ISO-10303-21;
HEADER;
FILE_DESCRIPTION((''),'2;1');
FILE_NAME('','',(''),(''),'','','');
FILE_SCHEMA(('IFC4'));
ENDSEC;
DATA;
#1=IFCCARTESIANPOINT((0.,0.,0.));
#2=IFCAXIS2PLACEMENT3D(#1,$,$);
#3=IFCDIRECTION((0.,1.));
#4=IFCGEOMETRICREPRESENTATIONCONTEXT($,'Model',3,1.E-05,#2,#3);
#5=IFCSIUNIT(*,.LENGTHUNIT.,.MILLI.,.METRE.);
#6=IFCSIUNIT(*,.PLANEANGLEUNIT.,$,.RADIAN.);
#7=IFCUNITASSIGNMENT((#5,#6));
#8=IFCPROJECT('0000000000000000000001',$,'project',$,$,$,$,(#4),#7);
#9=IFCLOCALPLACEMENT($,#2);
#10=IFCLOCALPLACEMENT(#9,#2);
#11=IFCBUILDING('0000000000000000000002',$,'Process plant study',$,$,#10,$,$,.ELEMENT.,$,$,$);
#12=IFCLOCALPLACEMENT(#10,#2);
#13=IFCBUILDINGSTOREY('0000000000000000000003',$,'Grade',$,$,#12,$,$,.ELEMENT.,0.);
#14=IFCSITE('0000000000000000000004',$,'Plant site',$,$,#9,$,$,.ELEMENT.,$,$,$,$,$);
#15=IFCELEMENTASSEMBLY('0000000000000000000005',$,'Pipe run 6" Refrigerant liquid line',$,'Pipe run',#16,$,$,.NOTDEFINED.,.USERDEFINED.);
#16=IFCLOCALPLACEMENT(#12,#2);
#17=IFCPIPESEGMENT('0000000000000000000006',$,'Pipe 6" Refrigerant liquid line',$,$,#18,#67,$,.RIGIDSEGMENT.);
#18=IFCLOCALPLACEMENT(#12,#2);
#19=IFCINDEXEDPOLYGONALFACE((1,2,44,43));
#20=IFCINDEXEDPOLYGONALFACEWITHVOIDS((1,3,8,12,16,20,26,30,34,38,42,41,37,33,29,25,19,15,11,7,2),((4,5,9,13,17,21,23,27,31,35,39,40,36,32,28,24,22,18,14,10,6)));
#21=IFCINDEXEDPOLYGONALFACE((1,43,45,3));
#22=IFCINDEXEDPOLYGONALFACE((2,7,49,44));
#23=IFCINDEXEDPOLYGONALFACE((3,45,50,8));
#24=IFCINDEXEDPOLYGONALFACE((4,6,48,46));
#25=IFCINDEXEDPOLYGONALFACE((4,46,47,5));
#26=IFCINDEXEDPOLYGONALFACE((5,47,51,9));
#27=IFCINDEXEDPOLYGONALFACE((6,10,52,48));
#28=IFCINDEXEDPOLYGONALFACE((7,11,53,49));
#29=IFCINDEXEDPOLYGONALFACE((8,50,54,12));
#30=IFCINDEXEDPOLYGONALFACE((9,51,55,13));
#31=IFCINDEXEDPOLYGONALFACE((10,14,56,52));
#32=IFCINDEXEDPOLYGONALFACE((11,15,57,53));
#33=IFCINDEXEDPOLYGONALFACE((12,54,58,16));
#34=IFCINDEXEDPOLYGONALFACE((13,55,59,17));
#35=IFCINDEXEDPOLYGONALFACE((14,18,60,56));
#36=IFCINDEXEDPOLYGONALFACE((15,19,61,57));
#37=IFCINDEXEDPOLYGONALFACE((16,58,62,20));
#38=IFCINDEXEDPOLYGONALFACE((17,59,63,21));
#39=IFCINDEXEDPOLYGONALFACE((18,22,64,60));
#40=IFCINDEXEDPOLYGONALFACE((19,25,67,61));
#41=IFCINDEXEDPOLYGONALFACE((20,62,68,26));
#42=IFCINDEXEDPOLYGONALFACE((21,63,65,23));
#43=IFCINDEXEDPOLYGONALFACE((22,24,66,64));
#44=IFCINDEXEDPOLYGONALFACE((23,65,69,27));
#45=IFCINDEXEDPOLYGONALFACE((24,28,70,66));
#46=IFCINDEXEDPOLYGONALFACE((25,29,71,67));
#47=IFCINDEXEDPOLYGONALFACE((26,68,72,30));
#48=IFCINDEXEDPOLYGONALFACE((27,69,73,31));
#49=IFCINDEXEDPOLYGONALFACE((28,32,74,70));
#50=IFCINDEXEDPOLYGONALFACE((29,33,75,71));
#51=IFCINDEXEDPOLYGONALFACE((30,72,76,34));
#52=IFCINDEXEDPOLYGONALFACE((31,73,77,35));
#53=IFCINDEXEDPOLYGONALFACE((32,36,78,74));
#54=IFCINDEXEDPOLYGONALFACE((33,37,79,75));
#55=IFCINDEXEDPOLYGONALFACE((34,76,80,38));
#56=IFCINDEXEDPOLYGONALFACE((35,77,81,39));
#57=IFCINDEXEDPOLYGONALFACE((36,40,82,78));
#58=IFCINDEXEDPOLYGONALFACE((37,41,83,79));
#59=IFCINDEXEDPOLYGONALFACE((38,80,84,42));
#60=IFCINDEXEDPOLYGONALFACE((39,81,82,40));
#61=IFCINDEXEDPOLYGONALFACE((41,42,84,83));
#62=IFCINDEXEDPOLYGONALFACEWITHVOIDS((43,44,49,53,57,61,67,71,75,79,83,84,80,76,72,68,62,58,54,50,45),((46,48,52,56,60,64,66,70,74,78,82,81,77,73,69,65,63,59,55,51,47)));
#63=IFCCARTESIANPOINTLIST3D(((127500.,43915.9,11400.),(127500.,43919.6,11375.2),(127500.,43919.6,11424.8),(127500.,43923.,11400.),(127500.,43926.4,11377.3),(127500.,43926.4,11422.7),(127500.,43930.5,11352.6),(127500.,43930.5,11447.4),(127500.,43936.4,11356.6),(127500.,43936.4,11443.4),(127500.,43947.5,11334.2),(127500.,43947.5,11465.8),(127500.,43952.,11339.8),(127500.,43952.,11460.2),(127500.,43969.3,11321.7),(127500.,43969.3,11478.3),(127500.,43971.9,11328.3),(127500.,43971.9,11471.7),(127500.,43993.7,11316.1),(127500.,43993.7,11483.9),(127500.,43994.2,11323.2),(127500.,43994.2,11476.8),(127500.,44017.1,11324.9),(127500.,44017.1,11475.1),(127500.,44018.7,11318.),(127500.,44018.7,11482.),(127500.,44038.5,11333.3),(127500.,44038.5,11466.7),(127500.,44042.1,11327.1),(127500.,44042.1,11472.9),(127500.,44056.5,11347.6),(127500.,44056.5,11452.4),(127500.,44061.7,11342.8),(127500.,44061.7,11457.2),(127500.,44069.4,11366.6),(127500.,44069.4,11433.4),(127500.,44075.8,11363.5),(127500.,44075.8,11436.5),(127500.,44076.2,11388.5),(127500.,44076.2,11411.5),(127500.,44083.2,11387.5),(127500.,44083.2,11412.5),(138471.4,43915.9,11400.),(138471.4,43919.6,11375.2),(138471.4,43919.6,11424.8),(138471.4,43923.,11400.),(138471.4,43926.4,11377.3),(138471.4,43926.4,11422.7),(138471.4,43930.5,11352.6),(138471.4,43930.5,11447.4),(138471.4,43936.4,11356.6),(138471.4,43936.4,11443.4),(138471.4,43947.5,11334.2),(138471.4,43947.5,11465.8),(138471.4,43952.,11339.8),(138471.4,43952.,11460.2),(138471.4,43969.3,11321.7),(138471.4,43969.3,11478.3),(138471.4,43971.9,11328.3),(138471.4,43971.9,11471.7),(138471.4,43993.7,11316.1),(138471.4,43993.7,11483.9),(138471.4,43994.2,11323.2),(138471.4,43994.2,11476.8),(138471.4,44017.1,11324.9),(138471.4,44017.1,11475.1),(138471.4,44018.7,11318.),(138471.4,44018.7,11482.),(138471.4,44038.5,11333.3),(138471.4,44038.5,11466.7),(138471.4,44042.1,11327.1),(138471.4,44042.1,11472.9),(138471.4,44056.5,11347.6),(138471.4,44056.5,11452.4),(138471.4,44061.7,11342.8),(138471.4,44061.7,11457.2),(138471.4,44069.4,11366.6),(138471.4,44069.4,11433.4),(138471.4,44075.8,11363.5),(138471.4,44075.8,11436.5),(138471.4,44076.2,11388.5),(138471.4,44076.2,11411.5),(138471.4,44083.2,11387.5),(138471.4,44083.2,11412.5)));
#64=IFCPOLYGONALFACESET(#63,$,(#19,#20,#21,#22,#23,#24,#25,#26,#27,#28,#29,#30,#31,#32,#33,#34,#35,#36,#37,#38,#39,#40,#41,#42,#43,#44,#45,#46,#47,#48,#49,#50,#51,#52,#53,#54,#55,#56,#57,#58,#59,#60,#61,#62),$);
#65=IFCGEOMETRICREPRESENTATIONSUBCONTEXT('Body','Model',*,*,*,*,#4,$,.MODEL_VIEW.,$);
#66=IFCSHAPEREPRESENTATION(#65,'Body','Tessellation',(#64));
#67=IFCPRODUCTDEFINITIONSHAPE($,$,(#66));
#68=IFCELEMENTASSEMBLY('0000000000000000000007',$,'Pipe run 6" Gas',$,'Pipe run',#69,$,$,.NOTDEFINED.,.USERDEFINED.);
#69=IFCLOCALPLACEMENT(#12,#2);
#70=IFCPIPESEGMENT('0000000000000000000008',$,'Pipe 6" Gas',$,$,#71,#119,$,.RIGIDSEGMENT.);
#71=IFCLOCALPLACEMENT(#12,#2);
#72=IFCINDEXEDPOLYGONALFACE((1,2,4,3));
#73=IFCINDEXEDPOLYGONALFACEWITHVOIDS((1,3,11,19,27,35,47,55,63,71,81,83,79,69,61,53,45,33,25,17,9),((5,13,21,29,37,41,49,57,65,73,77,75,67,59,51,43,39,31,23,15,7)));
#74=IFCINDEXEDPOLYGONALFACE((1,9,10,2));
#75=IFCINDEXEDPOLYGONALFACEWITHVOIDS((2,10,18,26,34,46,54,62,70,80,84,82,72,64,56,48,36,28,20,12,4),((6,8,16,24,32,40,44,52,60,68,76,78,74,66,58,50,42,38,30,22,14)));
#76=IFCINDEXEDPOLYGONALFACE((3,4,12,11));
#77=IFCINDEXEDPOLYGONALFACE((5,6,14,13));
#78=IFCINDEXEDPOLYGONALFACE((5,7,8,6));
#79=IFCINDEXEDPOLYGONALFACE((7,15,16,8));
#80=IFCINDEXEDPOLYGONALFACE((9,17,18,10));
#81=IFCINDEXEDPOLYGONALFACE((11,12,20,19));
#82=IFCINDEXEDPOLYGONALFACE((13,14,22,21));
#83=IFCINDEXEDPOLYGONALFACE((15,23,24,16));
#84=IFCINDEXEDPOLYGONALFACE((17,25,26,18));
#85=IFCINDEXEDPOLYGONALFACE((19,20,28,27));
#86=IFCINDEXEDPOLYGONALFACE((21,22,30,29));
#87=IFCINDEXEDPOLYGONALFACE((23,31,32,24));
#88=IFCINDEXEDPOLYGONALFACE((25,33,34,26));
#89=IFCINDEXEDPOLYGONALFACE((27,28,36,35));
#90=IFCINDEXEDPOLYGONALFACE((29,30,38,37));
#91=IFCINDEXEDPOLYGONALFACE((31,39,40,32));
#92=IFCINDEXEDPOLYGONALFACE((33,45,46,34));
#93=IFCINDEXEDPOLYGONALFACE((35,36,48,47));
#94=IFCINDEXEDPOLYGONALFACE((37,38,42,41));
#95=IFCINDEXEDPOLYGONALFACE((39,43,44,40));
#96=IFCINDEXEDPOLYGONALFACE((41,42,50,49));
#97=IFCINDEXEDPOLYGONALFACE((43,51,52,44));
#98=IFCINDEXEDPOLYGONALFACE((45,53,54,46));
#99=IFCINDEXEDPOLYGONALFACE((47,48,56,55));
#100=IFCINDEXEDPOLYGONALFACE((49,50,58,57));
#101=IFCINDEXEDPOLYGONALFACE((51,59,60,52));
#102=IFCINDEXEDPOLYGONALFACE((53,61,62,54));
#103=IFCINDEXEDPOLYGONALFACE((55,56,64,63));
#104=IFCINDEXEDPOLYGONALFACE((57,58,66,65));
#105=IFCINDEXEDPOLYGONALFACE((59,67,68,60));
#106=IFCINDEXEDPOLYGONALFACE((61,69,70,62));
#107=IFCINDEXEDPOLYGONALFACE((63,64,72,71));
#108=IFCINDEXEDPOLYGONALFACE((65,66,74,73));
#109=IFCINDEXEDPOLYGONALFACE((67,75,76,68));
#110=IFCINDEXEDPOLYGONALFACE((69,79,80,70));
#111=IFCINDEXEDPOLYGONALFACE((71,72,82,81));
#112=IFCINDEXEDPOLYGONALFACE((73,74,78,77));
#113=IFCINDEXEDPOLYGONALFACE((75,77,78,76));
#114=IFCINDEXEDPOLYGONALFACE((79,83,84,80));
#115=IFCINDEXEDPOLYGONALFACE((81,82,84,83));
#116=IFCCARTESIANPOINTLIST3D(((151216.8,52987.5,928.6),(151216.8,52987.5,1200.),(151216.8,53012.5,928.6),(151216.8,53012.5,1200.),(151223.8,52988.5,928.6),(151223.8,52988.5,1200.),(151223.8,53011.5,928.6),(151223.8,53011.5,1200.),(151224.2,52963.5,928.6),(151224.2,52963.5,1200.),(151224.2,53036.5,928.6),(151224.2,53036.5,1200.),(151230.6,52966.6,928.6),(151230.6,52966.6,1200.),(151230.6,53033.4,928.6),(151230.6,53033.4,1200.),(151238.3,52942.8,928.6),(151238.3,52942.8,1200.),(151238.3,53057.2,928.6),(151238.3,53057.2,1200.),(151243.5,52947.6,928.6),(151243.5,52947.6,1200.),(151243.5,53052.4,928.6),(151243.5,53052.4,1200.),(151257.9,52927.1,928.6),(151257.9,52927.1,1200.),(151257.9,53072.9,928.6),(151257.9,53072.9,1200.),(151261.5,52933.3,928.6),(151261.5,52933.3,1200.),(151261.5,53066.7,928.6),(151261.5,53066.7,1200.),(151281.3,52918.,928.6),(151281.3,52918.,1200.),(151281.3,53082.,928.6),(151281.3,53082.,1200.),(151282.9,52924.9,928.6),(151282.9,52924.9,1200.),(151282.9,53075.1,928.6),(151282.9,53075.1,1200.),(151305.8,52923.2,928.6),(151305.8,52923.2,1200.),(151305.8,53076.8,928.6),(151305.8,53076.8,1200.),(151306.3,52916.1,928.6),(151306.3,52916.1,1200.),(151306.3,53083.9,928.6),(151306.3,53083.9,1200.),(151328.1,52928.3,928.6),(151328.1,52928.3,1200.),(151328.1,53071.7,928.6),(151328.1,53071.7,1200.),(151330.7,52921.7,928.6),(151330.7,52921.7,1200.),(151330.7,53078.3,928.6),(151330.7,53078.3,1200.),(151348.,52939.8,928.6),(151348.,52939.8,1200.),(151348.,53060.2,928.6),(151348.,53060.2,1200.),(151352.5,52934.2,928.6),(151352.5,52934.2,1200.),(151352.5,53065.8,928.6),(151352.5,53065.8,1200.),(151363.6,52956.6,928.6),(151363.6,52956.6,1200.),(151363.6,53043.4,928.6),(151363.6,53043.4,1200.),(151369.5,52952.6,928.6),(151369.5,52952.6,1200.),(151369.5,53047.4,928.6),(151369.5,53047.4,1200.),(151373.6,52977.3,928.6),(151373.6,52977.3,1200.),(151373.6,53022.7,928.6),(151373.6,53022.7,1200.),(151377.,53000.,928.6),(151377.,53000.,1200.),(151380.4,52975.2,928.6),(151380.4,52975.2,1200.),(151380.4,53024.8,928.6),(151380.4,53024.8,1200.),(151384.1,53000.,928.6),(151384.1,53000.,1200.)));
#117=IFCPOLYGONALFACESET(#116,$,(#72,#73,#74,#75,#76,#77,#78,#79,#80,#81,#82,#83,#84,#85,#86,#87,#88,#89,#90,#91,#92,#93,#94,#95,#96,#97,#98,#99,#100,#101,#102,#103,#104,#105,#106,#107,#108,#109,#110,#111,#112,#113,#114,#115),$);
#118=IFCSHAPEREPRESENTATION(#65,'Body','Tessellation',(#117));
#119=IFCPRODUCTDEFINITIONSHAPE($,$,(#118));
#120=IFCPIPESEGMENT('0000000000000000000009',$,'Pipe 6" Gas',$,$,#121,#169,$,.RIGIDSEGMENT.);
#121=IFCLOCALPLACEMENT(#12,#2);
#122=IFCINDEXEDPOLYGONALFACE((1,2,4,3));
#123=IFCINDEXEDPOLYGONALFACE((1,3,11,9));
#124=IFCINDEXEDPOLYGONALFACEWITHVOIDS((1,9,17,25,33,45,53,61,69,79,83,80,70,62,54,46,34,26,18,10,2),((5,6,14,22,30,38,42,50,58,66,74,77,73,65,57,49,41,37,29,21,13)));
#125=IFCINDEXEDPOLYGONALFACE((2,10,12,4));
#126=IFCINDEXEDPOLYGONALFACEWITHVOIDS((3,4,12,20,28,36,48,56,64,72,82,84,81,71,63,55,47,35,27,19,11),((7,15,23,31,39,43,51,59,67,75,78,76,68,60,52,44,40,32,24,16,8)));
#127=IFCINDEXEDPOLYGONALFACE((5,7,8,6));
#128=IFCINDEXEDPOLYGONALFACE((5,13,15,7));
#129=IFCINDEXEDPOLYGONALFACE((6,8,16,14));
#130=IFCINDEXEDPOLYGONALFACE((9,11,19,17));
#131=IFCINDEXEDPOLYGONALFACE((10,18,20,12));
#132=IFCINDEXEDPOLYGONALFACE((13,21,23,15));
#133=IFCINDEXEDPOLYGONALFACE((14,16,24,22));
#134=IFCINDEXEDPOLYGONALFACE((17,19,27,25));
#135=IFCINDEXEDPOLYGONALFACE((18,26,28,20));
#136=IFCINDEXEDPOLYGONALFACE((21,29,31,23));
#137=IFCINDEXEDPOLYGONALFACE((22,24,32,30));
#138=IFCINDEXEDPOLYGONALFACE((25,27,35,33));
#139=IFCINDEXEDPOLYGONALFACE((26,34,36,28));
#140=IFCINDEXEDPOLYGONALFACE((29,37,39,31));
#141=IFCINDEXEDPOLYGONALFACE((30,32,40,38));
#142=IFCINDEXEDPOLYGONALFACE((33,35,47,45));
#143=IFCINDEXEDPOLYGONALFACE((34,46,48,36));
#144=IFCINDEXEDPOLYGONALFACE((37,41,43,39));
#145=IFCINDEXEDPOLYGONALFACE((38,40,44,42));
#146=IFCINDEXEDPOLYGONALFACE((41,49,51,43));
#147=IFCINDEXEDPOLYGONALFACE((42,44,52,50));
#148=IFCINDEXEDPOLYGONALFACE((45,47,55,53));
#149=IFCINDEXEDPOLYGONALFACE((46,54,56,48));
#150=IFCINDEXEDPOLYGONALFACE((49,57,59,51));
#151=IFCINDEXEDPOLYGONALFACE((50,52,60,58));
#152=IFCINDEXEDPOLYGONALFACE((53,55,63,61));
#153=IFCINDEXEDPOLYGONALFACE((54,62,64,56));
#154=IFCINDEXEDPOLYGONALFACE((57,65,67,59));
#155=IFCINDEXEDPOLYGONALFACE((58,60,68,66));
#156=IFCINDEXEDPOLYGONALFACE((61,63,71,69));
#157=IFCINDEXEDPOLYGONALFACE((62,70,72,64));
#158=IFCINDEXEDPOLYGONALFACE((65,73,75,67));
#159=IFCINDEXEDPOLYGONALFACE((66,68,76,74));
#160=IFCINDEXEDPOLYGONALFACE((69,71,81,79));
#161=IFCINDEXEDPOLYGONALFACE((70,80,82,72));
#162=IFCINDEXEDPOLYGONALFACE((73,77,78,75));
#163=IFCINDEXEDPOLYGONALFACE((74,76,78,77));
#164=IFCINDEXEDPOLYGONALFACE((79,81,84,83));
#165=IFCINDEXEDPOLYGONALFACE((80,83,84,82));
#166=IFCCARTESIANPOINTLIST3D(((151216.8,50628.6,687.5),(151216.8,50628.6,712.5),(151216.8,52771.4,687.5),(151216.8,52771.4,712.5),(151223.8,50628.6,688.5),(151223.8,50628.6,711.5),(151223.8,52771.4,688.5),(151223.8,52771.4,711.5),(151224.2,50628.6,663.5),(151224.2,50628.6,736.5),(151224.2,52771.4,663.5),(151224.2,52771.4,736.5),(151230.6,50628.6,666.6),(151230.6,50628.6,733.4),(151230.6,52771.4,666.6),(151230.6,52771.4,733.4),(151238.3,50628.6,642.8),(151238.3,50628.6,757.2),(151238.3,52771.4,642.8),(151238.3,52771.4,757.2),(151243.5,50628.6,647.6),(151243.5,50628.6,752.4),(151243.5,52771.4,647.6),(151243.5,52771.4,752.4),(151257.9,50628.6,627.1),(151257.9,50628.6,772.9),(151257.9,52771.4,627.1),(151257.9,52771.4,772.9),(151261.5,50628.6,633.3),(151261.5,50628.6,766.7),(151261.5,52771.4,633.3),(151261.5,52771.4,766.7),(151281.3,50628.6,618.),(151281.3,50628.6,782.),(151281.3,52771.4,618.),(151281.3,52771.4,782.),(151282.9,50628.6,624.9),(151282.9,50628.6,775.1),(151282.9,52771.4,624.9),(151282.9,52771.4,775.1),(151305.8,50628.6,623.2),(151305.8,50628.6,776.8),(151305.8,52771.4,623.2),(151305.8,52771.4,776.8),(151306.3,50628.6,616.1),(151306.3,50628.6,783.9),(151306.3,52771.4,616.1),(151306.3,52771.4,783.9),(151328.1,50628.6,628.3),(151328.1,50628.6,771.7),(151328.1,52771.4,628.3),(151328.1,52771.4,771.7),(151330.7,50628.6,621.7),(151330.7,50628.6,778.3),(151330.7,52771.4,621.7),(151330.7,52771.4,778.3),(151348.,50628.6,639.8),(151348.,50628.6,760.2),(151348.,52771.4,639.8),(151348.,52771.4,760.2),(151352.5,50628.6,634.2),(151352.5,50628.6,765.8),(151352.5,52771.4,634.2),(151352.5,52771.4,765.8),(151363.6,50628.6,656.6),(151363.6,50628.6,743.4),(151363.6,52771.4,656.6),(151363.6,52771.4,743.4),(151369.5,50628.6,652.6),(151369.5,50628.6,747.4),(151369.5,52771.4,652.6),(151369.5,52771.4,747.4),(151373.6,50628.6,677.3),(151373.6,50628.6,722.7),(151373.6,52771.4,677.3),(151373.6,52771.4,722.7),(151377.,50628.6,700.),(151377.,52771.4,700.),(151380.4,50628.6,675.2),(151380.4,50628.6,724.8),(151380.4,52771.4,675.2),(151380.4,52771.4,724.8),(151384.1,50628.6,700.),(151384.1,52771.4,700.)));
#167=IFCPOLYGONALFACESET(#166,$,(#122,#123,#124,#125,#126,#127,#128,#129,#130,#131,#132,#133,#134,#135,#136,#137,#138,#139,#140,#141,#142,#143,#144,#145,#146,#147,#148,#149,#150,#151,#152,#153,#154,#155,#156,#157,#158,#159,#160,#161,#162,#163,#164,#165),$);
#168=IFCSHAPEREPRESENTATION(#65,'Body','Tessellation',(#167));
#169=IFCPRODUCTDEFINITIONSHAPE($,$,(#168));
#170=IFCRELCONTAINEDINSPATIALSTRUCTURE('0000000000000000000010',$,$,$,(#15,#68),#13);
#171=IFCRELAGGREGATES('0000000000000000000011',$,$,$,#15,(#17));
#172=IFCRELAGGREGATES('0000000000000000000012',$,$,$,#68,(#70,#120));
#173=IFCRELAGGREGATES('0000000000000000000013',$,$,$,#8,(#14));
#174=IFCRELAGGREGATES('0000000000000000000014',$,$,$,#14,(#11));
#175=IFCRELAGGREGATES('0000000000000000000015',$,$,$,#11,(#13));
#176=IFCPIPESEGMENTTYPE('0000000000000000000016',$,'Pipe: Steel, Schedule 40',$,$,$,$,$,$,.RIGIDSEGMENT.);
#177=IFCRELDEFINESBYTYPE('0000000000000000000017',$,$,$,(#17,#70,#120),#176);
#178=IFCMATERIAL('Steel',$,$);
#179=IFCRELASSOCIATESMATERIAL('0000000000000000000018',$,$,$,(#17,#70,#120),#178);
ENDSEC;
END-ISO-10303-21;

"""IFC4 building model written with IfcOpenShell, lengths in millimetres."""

from ifc_helpers import new_model, si_unit, direction, frame, origin, origin_with_axes, origin_2d, place, context, subcontext, project, spatial, hollow_circle, extrude, material, type_object, element, aggregate, save


model = new_model("IFC4")

# Units and contexts
model_context = context("Model", 3, precision=1e-05, world=origin(), true_north=direction((0.0, 1.0)))
body_context = subcontext(model_context, "Body", "Model", "MODEL_VIEW")
ifc_project = project(units=[si_unit("LENGTHUNIT", "METRE", prefix="MILLI"), si_unit("PLANEANGLEUNIT", "RADIAN")], contexts=[model_context])

# Site, building, storey
site_placement = place(None, origin())
site = spatial("IfcSite", under=ifc_project, at=site_placement, Name="Plant site", CompositionType="ELEMENT")
building_placement = place(site_placement, origin())
building = spatial("IfcBuilding", under=site, at=building_placement, Name="Process plant study", CompositionType="ELEMENT")
storey_placement = place(building_placement, origin())
storey = spatial("IfcBuildingStorey", under=building, at=storey_placement, Name="Grade", CompositionType="ELEMENT", Elevation=0.0)

# Shared definitions
ifc_material = material(Name="Steel")
pipe_segment_type = type_object("IfcPipeSegmentType", Name="Pipe: Steel, Schedule 40", PredefinedType="RIGIDSEGMENT")

# Element assemblies, pipe segments
assembly_1_placement = place(storey_placement, origin_with_axes())
assembly_1 = element("IfcElementAssembly", 1, at=assembly_1_placement, inside=storey, Name="Pipe run 6\" Refrigerant liquid line", ObjectType="Pipe run", AssemblyPlace="NOTDEFINED", PredefinedType="USERDEFINED")
pipe_segment_1_placement = place(storey_placement, origin_with_axes())
pipe_segment_1 = element("IfcPipeSegment", 2, at=pipe_segment_1_placement, type_object=pipe_segment_type, material=ifc_material, Name="Pipe 6\" Refrigerant liquid line", PredefinedType="RIGIDSEGMENT", context=body_context, shape_type="SweptSolid", body=[
    extrude(hollow_circle(Radius=84.1, WallThickness=7.1, at=origin_2d()), frame((138471.4, 44000.0, 11400.0), z_axis=(-1.0, 0.0, 0.0), x_axis=(0.0, -1.0, 0.0)), (0.0, 0.0, 1.0), 10971.4),
])
assembly_2_placement = place(storey_placement, origin_with_axes())
assembly_2 = element("IfcElementAssembly", 3, at=assembly_2_placement, inside=storey, Name="Pipe run 6\" Gas", ObjectType="Pipe run", AssemblyPlace="NOTDEFINED", PredefinedType="USERDEFINED")
pipe_segment_2_placement = place(storey_placement, origin_with_axes())
pipe_segment_2 = element("IfcPipeSegment", 4, at=pipe_segment_2_placement, type_object=pipe_segment_type, material=ifc_material, Name="Pipe 6\" Gas", PredefinedType="RIGIDSEGMENT", context=body_context, shape_type="SweptSolid", body=[
    extrude(hollow_circle(Radius=84.1, WallThickness=7.1, at=origin_2d()), frame((151300.0, 53000.0, 1200.0), z_axis=(0.0, 0.0, -1.0), x_axis=(1.0, 0.0, 0.0)), (0.0, 0.0, 1.0), 271.4),
])
pipe_segment_3_placement = place(storey_placement, origin_with_axes())
pipe_segment_3 = element("IfcPipeSegment", 5, at=pipe_segment_3_placement, type_object=pipe_segment_type, material=ifc_material, Name="Pipe 6\" Gas", PredefinedType="RIGIDSEGMENT", context=body_context, shape_type="SweptSolid", body=[
    extrude(hollow_circle(Radius=84.1, WallThickness=7.1, at=origin_2d()), frame((151300.0, 52771.4, 700.0), z_axis=(0.0, -1.0, 0.0), x_axis=(1.0, 0.0, 0.0)), (0.0, 0.0, 1.0), 2142.8),
])

aggregate(assembly_1, [pipe_segment_1])
aggregate(assembly_2, [pipe_segment_2, pipe_segment_3])

save(model, "model.ifc")
